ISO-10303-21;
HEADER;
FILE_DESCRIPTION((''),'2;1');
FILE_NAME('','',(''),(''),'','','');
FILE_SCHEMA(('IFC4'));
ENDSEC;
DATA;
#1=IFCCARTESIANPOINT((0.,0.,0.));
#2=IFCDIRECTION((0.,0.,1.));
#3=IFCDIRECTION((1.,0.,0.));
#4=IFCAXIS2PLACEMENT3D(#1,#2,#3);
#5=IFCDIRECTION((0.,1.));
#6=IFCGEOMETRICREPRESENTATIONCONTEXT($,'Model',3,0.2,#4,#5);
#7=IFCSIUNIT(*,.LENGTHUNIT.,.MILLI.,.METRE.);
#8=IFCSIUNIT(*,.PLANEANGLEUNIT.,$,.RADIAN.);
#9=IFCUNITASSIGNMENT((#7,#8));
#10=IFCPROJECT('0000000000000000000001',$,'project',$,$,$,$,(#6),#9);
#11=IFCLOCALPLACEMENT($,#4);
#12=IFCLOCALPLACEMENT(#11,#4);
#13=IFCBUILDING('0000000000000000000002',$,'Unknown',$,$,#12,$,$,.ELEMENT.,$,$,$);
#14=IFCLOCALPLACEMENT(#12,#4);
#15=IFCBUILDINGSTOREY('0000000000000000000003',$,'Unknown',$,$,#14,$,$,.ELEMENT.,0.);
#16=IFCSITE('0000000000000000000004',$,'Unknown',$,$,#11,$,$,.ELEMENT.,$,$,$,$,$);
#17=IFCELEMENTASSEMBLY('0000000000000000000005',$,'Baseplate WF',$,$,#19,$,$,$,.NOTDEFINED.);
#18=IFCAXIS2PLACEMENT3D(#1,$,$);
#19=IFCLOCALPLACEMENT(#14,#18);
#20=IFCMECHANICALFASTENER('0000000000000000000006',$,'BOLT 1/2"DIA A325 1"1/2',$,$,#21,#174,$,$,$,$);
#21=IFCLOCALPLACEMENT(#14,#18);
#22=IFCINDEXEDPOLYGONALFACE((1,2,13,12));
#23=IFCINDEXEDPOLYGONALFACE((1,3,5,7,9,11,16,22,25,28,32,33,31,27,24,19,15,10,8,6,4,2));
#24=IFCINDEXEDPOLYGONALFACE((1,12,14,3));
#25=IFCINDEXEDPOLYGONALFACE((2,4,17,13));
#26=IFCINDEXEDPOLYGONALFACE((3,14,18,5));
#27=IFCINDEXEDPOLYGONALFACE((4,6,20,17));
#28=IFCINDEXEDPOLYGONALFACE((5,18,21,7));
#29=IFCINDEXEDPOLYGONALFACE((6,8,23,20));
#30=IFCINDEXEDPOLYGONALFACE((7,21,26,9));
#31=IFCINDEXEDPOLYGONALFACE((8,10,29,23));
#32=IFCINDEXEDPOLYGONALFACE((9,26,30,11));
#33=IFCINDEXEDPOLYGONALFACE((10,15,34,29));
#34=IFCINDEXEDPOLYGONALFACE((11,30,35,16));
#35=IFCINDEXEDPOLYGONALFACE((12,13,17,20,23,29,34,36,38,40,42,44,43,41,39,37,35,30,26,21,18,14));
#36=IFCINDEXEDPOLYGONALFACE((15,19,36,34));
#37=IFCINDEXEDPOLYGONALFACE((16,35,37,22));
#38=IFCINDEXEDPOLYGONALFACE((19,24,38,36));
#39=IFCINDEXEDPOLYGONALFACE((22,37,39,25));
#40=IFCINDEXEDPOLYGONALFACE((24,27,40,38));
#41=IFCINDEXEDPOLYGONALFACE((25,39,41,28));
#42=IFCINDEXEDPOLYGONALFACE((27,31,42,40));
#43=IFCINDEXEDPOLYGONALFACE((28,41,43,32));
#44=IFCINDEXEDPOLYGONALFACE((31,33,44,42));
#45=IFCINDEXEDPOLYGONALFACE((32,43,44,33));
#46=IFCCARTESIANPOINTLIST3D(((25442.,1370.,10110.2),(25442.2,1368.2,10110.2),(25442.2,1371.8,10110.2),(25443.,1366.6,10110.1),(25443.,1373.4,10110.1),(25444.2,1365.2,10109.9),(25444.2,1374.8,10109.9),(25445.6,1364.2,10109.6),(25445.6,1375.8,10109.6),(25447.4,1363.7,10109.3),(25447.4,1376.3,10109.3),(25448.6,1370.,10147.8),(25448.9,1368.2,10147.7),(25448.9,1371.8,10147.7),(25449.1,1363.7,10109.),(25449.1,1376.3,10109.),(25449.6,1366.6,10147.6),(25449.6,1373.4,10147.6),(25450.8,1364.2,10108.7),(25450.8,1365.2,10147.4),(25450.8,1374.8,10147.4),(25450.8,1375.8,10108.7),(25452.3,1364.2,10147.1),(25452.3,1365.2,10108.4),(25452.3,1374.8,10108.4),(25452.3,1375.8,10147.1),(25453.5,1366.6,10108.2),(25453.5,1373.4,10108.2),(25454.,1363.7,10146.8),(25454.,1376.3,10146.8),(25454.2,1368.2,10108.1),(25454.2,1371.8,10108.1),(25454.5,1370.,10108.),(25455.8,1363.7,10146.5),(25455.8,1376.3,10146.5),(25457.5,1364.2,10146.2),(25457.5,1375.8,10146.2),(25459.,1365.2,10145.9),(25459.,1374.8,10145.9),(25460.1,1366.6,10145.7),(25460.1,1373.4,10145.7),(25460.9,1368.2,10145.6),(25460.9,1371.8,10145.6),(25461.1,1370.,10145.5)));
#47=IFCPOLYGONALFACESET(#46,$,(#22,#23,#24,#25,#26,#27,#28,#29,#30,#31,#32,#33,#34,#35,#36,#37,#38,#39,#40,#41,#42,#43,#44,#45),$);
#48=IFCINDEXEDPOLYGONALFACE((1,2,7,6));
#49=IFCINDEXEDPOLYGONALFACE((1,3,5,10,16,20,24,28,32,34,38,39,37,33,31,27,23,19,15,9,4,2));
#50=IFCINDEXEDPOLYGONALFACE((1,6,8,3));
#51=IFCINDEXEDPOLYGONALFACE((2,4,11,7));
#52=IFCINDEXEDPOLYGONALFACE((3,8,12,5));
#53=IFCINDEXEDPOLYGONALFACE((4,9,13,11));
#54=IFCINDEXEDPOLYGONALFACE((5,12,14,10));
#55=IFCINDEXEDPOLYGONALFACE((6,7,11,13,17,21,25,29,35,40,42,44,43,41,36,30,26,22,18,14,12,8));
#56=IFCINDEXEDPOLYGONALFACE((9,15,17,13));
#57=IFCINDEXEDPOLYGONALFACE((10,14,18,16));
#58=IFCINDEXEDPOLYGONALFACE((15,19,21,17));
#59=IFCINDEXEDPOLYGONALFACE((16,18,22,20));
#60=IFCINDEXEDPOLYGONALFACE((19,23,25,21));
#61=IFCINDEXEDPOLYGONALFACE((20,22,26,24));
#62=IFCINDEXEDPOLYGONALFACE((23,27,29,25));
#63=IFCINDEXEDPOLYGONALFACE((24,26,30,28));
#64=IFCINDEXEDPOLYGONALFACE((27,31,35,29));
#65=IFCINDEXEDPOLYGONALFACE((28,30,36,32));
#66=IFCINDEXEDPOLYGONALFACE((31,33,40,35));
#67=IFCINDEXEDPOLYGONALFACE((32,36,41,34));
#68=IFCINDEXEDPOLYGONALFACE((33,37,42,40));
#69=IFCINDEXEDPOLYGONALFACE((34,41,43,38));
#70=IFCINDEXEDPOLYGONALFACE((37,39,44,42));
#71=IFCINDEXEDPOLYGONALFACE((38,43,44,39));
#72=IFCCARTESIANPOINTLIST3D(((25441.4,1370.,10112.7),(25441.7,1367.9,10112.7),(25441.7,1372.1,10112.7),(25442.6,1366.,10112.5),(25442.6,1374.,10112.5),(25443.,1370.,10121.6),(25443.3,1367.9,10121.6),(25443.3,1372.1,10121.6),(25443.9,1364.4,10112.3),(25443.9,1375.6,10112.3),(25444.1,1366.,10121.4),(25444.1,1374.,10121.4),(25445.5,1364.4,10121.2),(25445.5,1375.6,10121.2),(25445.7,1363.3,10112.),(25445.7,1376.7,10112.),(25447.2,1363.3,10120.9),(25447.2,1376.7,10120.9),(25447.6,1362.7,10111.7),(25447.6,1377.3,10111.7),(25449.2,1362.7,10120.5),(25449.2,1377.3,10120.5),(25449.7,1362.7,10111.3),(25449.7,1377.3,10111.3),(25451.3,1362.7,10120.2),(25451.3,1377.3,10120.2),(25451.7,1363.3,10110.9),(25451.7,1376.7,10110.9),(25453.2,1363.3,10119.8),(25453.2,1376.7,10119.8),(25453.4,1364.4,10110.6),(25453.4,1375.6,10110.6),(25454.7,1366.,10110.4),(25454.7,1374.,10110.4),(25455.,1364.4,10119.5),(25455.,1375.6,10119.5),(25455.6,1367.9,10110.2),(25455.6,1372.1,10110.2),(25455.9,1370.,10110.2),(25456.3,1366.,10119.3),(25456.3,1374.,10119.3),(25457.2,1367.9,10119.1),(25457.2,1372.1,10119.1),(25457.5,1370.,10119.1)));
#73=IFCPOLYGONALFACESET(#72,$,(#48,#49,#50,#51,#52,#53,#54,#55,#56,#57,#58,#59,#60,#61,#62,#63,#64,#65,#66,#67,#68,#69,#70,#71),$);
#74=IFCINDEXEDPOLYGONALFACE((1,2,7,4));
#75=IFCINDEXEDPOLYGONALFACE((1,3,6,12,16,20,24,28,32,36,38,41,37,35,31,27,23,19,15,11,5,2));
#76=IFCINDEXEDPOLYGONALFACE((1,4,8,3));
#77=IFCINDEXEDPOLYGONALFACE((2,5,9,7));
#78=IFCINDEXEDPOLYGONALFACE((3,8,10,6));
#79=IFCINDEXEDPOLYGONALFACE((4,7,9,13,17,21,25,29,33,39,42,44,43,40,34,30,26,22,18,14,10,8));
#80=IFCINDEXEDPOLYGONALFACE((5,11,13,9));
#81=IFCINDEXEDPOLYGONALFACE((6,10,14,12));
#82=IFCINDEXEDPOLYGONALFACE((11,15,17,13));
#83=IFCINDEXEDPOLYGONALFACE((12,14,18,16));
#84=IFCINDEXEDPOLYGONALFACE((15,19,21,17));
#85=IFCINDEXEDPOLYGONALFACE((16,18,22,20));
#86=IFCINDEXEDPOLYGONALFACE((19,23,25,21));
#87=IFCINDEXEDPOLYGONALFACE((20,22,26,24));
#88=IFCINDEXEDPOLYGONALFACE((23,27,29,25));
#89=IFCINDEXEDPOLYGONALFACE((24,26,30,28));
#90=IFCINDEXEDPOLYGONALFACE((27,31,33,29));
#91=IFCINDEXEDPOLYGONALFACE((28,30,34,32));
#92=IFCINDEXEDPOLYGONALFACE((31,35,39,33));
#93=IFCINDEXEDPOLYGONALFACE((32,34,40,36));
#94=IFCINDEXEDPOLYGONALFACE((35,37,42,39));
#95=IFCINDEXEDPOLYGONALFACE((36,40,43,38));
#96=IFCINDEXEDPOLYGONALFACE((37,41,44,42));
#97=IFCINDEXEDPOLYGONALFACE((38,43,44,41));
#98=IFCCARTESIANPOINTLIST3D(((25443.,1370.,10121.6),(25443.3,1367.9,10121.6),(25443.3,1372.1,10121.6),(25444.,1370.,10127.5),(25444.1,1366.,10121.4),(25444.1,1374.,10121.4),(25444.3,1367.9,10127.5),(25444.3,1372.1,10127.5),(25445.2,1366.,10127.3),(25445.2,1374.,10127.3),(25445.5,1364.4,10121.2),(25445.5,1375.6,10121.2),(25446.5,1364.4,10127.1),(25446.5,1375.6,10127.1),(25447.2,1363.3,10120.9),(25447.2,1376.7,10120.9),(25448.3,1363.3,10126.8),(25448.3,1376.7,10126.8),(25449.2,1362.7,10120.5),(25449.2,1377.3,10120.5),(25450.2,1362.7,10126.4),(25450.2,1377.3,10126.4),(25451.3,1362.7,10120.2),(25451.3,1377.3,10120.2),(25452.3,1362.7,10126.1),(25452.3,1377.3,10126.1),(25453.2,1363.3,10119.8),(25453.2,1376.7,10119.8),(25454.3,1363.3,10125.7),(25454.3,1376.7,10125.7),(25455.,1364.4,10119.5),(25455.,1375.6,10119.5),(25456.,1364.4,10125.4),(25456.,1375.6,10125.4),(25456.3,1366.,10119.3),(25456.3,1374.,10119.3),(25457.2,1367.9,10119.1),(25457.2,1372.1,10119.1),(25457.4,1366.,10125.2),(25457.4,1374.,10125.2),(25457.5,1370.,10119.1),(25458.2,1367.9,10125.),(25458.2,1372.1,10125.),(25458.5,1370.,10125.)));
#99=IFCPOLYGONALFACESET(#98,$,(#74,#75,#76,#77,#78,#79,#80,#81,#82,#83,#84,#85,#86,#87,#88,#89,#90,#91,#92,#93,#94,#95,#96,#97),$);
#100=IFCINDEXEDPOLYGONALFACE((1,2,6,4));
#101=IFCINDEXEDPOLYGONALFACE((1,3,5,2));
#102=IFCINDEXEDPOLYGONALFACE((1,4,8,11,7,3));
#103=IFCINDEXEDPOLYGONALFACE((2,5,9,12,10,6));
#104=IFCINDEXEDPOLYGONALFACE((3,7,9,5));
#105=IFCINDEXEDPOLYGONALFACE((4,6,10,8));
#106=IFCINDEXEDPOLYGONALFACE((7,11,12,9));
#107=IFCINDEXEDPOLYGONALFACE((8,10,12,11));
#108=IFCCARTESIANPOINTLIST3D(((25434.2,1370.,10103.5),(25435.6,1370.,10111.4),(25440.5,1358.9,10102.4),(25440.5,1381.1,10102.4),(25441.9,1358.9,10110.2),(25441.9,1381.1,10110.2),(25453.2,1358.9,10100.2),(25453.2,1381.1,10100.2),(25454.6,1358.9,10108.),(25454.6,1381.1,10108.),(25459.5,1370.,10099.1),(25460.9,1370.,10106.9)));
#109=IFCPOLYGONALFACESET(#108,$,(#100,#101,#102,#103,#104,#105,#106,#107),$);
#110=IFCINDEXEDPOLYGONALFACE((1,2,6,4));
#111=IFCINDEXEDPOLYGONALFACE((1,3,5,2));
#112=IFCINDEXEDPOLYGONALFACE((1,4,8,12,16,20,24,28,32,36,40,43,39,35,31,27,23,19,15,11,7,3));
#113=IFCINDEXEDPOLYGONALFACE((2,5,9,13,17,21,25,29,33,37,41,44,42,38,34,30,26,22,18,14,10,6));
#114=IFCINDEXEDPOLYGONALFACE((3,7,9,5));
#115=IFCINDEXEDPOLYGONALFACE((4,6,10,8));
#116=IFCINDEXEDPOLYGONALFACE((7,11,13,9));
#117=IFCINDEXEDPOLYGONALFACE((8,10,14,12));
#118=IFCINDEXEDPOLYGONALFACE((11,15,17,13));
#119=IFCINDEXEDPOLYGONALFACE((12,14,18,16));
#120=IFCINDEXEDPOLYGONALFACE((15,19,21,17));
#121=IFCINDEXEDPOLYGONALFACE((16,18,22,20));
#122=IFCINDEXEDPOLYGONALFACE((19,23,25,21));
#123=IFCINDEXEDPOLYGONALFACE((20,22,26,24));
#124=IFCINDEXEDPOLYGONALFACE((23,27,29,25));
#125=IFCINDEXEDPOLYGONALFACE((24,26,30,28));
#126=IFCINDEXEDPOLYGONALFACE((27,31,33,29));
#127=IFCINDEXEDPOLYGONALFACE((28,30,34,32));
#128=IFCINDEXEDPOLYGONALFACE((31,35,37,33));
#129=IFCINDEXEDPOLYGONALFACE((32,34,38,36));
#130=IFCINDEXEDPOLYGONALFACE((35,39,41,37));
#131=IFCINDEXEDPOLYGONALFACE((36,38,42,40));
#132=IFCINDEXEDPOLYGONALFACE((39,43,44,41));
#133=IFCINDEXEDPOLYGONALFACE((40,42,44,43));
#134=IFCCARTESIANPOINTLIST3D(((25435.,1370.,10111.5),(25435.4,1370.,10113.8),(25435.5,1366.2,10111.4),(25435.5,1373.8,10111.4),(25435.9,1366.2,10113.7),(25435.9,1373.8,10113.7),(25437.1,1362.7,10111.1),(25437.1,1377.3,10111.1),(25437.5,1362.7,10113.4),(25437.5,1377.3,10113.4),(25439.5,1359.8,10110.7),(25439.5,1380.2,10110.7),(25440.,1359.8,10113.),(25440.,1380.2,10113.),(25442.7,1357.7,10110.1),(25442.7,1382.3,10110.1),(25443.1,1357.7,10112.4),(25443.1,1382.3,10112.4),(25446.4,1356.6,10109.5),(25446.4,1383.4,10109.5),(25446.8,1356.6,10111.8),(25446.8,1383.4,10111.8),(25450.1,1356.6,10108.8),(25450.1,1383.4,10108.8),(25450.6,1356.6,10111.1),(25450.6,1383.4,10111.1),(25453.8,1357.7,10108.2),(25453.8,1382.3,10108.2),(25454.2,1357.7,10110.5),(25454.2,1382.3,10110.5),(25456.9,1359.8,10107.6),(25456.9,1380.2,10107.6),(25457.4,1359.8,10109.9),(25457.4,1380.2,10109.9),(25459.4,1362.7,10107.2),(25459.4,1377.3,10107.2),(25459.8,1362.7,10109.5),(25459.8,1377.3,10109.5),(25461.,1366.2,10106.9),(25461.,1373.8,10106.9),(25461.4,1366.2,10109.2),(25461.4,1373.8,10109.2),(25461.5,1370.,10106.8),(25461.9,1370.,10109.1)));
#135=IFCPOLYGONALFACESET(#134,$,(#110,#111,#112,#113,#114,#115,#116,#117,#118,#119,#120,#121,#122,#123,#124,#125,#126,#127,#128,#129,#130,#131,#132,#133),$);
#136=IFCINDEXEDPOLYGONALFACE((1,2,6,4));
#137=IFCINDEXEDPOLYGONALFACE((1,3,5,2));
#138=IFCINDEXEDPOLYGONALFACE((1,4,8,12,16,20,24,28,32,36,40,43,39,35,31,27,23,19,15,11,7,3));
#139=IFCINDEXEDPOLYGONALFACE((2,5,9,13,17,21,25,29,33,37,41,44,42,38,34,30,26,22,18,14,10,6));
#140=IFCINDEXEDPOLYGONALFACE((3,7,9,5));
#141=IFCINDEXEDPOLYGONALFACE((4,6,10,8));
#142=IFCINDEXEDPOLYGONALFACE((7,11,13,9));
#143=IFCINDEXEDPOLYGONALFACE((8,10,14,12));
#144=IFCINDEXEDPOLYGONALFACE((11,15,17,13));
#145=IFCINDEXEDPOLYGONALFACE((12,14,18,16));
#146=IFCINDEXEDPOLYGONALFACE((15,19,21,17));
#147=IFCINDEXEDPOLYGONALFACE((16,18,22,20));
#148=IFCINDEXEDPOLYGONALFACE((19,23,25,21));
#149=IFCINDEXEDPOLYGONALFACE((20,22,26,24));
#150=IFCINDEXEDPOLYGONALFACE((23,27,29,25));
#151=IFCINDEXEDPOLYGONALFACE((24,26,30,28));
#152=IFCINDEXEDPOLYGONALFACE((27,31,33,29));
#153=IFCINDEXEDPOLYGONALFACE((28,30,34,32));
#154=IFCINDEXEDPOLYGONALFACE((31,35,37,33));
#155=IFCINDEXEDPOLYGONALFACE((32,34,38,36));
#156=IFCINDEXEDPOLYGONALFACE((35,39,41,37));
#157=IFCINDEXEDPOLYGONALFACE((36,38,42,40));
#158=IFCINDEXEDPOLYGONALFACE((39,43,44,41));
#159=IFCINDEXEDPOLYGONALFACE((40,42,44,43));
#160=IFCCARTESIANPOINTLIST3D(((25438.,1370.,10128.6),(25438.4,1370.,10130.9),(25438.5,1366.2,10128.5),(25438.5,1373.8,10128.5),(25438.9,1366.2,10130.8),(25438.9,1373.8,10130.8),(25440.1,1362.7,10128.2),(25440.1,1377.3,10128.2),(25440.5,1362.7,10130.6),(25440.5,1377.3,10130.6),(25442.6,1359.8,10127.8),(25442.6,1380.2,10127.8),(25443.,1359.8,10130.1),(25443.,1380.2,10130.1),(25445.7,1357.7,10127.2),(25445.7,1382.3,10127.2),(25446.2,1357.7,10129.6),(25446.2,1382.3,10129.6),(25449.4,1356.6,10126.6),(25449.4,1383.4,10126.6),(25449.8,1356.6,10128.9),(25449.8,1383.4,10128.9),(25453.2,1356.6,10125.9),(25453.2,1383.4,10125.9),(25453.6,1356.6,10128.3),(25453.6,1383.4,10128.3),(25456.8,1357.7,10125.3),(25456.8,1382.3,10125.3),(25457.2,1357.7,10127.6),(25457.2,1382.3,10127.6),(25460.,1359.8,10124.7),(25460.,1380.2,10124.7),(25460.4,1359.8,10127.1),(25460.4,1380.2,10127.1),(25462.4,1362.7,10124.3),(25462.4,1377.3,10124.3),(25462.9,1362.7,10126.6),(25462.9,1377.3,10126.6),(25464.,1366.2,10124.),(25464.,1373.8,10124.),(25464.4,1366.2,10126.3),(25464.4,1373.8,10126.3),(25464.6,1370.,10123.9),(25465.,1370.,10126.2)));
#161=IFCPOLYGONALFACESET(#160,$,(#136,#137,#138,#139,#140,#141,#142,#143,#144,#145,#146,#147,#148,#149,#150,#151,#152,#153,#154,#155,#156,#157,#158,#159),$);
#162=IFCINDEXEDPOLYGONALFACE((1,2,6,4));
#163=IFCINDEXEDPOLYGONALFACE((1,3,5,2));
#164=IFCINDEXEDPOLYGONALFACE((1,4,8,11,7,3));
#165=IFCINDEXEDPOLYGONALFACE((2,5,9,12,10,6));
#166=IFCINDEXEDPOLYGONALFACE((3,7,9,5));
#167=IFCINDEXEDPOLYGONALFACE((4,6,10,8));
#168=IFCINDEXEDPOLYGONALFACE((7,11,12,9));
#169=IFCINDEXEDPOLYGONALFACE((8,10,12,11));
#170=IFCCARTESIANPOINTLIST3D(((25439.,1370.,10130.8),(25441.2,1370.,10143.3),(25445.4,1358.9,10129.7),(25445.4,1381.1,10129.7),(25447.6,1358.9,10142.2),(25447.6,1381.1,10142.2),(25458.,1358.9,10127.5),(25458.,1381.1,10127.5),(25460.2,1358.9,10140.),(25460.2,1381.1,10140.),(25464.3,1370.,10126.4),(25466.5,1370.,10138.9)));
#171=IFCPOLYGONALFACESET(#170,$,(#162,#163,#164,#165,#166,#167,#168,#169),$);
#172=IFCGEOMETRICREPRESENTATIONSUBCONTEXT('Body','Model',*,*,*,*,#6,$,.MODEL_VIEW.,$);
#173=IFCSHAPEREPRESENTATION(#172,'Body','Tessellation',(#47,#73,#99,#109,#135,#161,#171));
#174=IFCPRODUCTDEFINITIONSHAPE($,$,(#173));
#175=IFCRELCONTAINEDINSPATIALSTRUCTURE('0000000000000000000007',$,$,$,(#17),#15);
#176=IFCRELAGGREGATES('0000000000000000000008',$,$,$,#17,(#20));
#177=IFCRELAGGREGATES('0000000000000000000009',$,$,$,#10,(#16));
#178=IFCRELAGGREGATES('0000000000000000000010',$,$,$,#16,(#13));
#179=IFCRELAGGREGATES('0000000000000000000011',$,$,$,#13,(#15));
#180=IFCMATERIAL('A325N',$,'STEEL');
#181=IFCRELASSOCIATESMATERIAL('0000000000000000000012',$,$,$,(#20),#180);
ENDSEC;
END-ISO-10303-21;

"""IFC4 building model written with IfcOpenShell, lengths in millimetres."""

from ifc_helpers import new_model, si_unit, direction, frame, origin_with_axes, place, context, subcontext, project, spatial, line, arc, indexed_curve, outline, extrude, source, transform, mapped, material, element, aggregate, save


model = new_model("IFC4")

# Units and contexts
model_context = context("Model", 3, precision=0.2, world=origin_with_axes(), true_north=direction((0.0, 1.0)))
body_context = subcontext(model_context, "Body", "Model", "MODEL_VIEW")
ifc_project = project(units=[si_unit("LENGTHUNIT", "METRE", prefix="MILLI"), si_unit("PLANEANGLEUNIT", "RADIAN")], contexts=[model_context])

# Site, building, storey
site_placement = place(None, origin_with_axes())
site = spatial("IfcSite", under=ifc_project, at=site_placement, Name="Unknown", CompositionType="ELEMENT")
building_placement = place(site_placement, origin_with_axes())
building = spatial("IfcBuilding", under=site, at=building_placement, Name="Unknown", CompositionType="ELEMENT")
storey_placement = place(building_placement, origin_with_axes())
storey = spatial("IfcBuildingStorey", under=building, at=storey_placement, Name="Unknown", CompositionType="ELEMENT", Elevation=0.0)

# Element assembly
assembly_1_placement = place(storey_placement, frame((25480.3, 1400.0, 10118.1), z_axis=(-0.173648, 0.0, -0.984808), x_axis=(0.0, -1.0, 0.0)))
assembly_1 = element("IfcElementAssembly", 1, at=assembly_1_placement, inside=storey, Name="Baseplate WF", PredefinedType="NOTDEFINED")

# Mechanical fastener
ifc_material_1 = material(Name="A325N", Category="STEEL")
shared_shape_1 = source(origin_with_axes(), body_context, "Body", "SweptSolid", [
    extrude(outline(indexed_curve([(6.3, 0.0), (0.0, 6.3), (-6.3, 0.0), (0.0, -6.3)], segments=[arc(1, 2, 3), arc(3, 4, 1)])), frame((0.0, 0.0, 17.4), z_axis=(0.0, 0.0, -1.0), x_axis=(0.0, 1.0, 0.0)), (0.0, 0.0, 1.0), 38.1),
    extrude(outline(indexed_curve([(7.3, 0.0), (0.0, 7.3), (-7.3, 0.0), (0.0, -7.3)], segments=[arc(1, 2, 3), arc(3, 4, 1)])), frame((0.0, 0.0, 15.0), z_axis=(0.0, 0.0, -1.0), x_axis=(0.0, 1.0, 0.0)), (0.0, 0.0, 1.0), 9.0),
    extrude(outline(indexed_curve([(7.3, 0.0), (0.0, 7.3), (-7.3, 0.0), (0.0, -7.3)], segments=[arc(1, 2, 3), arc(3, 4, 1)])), frame((0.0, 0.0, 6.0), z_axis=(0.0, 0.0, -1.0), x_axis=(0.0, 1.0, 0.0)), (0.0, 0.0, 1.0), 6.0),
    extrude(outline(indexed_curve([(12.8, 0.0), (6.4, 11.1), (-6.4, 11.1), (-12.8, 0.0), (-6.4, -11.1), (6.4, -11.1)], segments=[line(1, 2, 3, 4, 5, 6, 1)])), frame((0.0, 0.0, 25.3), z_axis=(0.0, 0.0, -1.0), x_axis=(0.0, 1.0, 0.0)), (0.0, 0.0, 1.0), 7.9),
    extrude(outline(indexed_curve([(13.5, 0.0), (0.0, 13.5), (-13.5, 0.0), (0.0, -13.5)], segments=[arc(1, 2, 3), arc(3, 4, 1)])), frame((0.0, 0.0, 17.4), z_axis=(0.0, 0.0, -1.0), x_axis=(0.0, 1.0, 0.0)), (0.0, 0.0, 1.0), 2.4),
    extrude(outline(indexed_curve([(13.5, 0.0), (0.0, 13.5), (-13.5, 0.0), (0.0, -13.5)], segments=[arc(1, 2, 3), arc(3, 4, 1)])), frame((0.0, 0.0, 0.0), z_axis=(0.0, 0.0, -1.0), x_axis=(0.0, 1.0, 0.0)), (0.0, 0.0, 1.0), 2.4),
    extrude(outline(indexed_curve([(12.8, 0.0), (6.4, 11.1), (-6.4, 11.1), (-12.8, 0.0), (-6.4, -11.1), (6.4, -11.1)], segments=[line(1, 2, 3, 4, 5, 6, 1)])), frame((0.0, 0.0, -2.4), z_axis=(0.0, 0.0, -1.0), x_axis=(0.0, 1.0, 0.0)), (0.0, 0.0, 1.0), 12.7),
])
mechanical_fastener_1_placement = place(assembly_1_placement, frame((30.0, 30.0, -3.0), z_axis=(0.0, 0.0, 1.0), x_axis=(1.0, 0.0, 0.0)))
mechanical_fastener_1 = element("IfcMechanicalFastener", 2, at=mechanical_fastener_1_placement, material=ifc_material_1, Name="BOLT 1/2\"DIA A325 1\"1/2", context=body_context, shape_type="MappedRepresentation", body=[
    mapped(shared_shape_1, transform((0.0, 0.0, 0.0))),
])
aggregate(assembly_1, [mechanical_fastener_1])

save(model, "model.ifc")
